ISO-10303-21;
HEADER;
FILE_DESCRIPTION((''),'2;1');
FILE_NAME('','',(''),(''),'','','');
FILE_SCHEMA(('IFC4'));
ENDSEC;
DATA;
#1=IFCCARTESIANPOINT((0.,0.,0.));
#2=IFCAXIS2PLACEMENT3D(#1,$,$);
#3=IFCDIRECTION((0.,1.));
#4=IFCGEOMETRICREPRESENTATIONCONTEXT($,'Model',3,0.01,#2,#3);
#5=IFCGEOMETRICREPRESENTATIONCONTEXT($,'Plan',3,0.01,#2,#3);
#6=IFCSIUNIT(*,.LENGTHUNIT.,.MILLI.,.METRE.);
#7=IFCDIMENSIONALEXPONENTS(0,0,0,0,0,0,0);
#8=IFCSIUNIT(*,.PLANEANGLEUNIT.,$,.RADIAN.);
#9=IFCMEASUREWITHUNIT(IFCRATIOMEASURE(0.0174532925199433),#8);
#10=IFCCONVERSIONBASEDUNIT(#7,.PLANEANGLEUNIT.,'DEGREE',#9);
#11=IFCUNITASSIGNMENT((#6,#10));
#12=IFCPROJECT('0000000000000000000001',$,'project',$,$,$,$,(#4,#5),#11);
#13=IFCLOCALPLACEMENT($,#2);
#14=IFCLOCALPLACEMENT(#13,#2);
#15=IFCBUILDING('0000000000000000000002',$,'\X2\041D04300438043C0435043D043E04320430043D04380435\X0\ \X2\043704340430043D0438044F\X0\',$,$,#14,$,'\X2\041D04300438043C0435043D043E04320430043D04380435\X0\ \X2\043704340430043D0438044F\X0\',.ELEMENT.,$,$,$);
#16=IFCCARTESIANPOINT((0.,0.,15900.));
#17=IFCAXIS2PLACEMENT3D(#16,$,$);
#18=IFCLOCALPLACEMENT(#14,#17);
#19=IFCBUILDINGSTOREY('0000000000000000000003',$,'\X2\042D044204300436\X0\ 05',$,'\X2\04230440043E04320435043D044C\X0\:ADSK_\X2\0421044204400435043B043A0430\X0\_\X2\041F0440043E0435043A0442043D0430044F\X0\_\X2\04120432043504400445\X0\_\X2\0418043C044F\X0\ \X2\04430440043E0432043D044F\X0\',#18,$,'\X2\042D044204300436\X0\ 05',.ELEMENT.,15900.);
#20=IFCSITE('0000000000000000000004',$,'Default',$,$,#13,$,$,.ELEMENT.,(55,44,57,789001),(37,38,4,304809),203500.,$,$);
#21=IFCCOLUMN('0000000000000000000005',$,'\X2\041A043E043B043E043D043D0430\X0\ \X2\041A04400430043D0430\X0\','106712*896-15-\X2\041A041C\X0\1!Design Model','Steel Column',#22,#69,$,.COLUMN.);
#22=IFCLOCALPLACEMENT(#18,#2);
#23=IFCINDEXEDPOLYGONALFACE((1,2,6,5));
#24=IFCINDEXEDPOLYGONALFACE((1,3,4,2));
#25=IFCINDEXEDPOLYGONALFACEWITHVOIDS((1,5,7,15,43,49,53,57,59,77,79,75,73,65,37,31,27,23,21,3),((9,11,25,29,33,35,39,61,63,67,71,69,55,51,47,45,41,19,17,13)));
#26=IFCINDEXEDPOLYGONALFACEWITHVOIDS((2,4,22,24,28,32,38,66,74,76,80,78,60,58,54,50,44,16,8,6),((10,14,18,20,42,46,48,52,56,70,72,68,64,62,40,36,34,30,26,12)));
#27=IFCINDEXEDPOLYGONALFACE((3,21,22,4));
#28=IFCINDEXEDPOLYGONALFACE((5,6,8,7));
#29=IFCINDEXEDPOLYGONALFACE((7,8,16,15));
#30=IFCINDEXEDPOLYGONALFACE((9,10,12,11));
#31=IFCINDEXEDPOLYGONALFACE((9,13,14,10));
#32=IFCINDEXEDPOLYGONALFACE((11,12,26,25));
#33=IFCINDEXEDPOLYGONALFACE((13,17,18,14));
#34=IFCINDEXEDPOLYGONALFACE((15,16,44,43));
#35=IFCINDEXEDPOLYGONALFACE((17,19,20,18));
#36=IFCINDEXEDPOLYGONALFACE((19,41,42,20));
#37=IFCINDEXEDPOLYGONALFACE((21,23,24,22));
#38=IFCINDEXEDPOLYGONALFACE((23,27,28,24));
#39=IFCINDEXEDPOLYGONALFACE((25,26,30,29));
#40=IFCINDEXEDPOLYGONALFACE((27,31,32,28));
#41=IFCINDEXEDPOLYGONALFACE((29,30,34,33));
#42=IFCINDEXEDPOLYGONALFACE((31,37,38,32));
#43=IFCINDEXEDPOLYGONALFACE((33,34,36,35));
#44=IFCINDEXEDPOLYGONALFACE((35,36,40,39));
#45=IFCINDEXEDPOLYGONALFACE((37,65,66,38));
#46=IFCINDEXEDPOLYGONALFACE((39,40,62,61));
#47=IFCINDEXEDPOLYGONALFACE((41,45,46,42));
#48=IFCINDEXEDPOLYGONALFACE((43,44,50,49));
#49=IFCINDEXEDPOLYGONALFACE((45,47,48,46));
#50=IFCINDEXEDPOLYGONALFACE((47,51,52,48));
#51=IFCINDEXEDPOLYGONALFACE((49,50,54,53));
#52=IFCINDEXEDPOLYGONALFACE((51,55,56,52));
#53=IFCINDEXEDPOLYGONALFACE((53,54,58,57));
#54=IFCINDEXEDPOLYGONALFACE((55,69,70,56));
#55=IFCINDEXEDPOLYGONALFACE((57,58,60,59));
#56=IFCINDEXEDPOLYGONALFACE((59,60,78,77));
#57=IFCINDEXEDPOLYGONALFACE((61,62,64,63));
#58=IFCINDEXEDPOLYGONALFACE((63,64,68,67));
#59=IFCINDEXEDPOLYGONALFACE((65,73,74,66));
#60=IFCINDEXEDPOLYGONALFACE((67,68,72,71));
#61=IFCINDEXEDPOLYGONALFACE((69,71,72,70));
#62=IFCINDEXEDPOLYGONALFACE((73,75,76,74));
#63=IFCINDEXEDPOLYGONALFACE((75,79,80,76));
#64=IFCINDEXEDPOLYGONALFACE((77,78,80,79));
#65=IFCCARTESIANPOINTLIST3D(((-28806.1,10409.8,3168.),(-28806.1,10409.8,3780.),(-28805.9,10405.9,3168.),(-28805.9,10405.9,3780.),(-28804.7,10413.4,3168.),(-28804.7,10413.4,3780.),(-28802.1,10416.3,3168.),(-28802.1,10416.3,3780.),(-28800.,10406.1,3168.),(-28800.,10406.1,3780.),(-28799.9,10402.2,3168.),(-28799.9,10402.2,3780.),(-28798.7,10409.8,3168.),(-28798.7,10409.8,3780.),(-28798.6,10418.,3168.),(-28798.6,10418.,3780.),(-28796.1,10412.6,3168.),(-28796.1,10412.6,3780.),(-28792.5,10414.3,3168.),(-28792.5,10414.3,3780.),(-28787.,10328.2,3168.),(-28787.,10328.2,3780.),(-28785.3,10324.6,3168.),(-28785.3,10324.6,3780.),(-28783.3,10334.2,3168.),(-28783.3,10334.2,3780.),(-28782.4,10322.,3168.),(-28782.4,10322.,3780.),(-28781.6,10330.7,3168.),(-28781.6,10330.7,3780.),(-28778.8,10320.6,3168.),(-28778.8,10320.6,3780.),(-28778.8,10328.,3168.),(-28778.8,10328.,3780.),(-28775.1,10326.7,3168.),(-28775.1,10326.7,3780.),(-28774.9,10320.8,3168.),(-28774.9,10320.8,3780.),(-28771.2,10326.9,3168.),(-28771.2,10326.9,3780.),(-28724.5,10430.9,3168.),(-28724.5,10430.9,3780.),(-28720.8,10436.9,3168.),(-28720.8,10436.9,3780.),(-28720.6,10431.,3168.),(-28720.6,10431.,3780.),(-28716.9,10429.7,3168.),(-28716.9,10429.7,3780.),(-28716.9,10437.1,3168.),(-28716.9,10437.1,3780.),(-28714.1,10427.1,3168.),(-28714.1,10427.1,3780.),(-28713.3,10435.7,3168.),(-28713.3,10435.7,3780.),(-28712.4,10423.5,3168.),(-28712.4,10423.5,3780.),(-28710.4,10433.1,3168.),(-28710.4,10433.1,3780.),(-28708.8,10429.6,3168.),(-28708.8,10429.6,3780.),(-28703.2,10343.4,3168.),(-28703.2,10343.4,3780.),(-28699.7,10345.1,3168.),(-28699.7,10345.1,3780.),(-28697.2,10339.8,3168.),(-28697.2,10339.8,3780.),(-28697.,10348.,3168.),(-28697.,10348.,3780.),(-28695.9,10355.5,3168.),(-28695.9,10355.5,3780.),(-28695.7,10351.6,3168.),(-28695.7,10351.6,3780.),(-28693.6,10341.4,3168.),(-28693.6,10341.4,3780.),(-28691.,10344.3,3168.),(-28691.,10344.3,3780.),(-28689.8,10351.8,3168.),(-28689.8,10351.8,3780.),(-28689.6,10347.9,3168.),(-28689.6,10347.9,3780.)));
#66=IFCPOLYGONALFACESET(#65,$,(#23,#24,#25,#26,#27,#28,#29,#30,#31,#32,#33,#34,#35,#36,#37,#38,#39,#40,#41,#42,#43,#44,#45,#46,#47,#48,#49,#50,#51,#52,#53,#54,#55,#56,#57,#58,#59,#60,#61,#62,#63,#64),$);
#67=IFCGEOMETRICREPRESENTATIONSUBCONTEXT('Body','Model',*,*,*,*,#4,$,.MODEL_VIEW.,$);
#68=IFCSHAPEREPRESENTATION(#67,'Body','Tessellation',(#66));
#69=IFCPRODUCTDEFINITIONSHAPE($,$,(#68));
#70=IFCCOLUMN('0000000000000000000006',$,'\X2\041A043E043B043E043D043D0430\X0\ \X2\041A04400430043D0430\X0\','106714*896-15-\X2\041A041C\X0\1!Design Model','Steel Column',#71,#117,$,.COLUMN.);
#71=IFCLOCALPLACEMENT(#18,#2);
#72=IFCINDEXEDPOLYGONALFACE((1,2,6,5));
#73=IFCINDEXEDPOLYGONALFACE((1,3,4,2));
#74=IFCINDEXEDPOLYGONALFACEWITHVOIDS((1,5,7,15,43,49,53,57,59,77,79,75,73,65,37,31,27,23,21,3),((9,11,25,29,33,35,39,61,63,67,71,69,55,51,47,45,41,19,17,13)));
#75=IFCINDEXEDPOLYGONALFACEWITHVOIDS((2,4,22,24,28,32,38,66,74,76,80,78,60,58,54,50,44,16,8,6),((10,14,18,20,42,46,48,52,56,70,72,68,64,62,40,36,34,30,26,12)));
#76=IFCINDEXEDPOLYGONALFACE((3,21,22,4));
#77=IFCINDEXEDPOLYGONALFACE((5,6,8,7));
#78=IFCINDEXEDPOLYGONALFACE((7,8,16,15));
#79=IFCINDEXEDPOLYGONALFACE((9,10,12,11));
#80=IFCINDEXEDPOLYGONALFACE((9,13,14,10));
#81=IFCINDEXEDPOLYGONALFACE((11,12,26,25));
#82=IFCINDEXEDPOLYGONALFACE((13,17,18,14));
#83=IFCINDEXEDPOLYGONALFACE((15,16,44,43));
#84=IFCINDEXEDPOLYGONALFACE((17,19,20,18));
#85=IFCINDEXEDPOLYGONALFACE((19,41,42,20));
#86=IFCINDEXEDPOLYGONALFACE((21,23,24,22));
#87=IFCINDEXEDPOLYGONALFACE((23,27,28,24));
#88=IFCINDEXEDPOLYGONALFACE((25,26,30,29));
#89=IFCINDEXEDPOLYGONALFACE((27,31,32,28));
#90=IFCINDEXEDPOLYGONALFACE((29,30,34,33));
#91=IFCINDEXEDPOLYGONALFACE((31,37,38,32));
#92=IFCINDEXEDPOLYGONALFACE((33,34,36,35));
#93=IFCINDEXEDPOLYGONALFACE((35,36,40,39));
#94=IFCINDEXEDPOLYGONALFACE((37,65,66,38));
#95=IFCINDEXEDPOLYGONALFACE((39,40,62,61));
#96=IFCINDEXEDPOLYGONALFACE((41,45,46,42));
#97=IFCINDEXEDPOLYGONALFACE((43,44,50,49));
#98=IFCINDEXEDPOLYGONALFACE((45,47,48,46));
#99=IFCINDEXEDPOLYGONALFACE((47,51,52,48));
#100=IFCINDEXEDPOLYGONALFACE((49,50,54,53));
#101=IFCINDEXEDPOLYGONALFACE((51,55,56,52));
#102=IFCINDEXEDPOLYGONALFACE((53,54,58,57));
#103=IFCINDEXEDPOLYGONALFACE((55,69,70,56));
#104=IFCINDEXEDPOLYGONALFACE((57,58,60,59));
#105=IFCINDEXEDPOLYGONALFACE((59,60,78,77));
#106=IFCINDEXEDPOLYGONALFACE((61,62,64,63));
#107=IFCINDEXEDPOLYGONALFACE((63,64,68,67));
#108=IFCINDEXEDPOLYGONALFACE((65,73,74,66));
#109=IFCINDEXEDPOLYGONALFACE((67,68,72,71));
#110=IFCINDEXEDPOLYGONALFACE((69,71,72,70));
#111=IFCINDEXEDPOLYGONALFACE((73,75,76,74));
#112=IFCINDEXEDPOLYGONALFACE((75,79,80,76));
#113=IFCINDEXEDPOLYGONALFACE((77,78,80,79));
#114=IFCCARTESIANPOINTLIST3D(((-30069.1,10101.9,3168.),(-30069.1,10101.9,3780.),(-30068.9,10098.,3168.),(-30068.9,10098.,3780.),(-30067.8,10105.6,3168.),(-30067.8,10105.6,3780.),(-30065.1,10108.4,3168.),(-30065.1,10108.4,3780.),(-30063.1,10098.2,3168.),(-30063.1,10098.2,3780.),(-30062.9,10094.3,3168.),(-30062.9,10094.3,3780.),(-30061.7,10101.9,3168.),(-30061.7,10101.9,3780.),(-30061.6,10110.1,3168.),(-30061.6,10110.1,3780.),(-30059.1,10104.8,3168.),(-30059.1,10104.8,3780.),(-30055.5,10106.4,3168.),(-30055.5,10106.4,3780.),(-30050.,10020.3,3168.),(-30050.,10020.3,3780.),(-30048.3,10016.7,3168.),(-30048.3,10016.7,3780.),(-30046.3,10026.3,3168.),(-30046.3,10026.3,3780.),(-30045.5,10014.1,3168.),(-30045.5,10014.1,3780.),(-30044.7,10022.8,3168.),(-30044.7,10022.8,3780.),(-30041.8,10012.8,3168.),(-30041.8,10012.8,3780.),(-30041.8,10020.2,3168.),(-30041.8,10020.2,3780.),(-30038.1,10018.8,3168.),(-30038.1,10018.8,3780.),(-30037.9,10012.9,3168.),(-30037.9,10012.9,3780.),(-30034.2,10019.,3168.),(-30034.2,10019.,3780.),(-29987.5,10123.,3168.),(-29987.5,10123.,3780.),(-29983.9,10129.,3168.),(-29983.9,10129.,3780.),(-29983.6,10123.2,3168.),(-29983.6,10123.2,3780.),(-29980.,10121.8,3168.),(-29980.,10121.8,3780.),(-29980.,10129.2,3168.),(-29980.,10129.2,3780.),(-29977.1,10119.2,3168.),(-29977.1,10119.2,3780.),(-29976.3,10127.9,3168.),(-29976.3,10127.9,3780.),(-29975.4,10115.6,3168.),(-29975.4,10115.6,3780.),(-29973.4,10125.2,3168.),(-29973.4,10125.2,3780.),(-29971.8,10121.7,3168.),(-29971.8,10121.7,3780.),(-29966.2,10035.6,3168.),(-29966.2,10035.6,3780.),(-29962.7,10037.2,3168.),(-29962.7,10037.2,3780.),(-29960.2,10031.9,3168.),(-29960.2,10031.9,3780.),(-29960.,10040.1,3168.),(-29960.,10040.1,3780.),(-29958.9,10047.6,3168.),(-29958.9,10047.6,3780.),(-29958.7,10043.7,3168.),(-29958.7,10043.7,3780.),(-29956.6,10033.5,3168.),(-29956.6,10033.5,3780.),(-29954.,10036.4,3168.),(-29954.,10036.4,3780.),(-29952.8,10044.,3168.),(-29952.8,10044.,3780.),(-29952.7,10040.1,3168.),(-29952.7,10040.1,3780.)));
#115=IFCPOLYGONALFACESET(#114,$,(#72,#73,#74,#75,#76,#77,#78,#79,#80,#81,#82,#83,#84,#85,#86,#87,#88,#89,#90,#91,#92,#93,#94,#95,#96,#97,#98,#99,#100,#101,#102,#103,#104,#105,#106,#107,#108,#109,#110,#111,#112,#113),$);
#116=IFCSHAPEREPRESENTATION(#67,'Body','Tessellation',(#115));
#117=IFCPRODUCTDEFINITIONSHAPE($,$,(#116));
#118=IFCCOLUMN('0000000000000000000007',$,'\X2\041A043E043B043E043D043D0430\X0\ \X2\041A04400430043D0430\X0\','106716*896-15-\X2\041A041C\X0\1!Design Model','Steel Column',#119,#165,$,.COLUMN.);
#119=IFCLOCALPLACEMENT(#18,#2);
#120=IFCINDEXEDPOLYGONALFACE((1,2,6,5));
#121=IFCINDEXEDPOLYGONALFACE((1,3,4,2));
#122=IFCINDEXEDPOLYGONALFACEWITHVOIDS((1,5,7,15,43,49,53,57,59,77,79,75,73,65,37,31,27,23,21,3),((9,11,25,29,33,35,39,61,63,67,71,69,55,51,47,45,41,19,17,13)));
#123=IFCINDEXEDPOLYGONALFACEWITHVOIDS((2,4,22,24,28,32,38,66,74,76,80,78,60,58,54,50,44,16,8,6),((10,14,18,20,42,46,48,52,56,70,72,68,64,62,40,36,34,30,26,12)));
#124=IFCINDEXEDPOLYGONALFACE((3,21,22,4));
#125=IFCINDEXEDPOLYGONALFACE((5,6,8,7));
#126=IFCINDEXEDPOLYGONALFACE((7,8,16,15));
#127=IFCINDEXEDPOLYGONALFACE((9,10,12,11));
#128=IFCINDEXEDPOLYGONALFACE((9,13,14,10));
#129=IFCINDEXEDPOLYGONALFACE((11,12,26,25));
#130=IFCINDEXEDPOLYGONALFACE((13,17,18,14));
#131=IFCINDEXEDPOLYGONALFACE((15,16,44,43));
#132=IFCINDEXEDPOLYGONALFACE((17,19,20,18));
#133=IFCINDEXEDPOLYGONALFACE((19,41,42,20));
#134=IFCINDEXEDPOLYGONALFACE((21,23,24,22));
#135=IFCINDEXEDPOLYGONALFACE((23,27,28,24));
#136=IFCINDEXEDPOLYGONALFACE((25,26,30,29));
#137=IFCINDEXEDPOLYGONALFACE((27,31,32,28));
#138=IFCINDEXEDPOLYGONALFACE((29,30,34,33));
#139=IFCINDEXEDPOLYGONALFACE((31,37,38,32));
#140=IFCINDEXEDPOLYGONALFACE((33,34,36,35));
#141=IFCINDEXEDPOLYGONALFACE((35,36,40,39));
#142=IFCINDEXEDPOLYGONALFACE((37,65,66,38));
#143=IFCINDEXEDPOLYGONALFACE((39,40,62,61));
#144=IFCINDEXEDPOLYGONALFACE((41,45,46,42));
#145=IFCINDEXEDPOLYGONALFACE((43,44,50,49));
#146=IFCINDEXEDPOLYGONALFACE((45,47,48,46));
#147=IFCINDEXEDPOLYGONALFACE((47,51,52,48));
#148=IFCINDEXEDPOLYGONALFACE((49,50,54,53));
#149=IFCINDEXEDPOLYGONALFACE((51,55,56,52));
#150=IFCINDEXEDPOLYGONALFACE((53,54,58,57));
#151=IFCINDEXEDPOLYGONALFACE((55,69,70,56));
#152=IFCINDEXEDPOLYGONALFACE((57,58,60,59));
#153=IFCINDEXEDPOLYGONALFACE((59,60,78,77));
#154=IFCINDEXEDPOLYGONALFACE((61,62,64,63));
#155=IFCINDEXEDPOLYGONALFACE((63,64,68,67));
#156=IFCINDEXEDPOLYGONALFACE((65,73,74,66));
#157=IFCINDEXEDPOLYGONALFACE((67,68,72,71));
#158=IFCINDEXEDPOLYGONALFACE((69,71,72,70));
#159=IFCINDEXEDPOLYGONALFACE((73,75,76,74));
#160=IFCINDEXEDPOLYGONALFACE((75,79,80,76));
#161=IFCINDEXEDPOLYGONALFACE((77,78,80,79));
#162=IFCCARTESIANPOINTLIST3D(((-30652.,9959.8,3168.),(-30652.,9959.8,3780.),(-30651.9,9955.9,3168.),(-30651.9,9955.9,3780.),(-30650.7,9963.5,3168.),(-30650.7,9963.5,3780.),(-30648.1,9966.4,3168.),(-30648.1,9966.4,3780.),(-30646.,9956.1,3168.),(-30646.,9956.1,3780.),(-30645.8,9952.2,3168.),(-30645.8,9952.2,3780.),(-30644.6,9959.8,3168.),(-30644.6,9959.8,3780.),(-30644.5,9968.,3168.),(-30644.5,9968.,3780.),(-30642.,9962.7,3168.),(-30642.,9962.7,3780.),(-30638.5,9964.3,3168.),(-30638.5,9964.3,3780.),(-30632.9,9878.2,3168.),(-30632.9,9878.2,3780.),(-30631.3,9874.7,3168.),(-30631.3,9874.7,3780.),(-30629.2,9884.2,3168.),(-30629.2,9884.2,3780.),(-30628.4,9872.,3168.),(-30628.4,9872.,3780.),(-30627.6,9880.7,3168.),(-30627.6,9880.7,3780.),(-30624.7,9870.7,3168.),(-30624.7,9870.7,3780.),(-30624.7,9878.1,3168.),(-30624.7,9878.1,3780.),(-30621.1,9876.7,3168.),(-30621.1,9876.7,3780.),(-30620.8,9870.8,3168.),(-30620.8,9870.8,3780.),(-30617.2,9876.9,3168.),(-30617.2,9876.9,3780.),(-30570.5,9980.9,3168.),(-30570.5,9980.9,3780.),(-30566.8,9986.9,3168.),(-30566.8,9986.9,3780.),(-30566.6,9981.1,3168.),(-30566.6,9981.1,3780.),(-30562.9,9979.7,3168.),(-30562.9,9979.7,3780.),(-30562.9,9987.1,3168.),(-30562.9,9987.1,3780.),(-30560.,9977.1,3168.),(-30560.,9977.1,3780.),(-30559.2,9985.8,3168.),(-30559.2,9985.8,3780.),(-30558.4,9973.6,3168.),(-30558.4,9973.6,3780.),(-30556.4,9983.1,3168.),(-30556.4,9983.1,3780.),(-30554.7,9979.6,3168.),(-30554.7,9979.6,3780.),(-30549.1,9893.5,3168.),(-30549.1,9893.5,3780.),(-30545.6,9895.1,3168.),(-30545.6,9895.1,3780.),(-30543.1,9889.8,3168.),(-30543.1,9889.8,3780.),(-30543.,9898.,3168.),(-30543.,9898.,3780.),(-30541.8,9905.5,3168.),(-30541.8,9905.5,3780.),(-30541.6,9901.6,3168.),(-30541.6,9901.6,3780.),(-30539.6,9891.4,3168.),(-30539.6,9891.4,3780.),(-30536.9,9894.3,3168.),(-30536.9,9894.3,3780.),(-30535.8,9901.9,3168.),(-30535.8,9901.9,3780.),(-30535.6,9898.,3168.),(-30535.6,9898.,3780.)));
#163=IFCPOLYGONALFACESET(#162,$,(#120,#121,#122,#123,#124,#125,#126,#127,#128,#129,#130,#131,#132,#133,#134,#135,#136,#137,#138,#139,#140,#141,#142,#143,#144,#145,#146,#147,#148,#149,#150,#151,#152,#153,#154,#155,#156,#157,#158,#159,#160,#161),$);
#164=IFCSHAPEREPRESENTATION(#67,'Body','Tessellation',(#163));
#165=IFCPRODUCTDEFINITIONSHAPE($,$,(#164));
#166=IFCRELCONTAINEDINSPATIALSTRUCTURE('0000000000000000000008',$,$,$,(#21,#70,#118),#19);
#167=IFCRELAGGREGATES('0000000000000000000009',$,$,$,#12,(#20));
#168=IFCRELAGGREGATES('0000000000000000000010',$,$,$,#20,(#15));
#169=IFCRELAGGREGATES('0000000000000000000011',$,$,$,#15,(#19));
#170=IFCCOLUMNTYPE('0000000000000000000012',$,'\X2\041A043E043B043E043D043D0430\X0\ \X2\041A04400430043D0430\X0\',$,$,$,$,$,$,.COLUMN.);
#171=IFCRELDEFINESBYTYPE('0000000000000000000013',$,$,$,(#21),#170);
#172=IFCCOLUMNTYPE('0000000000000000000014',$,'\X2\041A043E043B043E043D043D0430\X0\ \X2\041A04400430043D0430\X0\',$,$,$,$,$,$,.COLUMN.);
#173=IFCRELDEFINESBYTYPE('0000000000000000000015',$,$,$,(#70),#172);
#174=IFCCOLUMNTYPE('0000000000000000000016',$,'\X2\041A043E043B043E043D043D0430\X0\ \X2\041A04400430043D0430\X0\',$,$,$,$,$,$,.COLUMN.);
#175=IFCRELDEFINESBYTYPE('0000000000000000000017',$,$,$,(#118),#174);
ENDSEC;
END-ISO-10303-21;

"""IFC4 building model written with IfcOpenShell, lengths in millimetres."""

from ifc_helpers import new_model, entity, si_unit, converted_unit, direction, frame, origin, place, context, subcontext, project, spatial, indexed_curve, outline, extrude, type_object, element, save


model = new_model("IFC4")

# Units and contexts
model_context = context("Model", 3, precision=0.01, world=origin(), true_north=direction((0.0, 1.0)))
plan_context = context("Plan", 3, precision=0.01, world=origin(), true_north=direction((0.0, 1.0)))
body_context = subcontext(model_context, "Body", "Model", "MODEL_VIEW")
ifc_project = project(units=[si_unit("LENGTHUNIT", "METRE", prefix="MILLI"), converted_unit("PLANEANGLEUNIT", "DEGREE", entity("IfcRatioMeasure", 0.0174532925199433), si_unit("PLANEANGLEUNIT", "RADIAN"), dimensions=[0, 0, 0, 0, 0, 0, 0])], contexts=[model_context, plan_context])

# Site, building, storey
site_placement = place(None, origin())
site = spatial("IfcSite", under=ifc_project, at=site_placement, Name="Default", CompositionType="ELEMENT", RefLatitude=(55, 44, 57, 789001), RefLongitude=(37, 38, 4, 304809), RefElevation=203500.0)
building_placement = place(site_placement, origin())
building = spatial("IfcBuilding", under=site, at=building_placement, Name="Наименование здания", LongName="Наименование здания", CompositionType="ELEMENT")
storey_placement = place(building_placement, frame((0.0, 0.0, 15900.0)))
storey = spatial("IfcBuildingStorey", under=building, at=storey_placement, Name="Этаж 05", ObjectType="Уровень:ADSK_Стрелка_Проектная_Вверх_Имя уровня", LongName="Этаж 05", CompositionType="ELEMENT", Elevation=15900.0)

# Columns
column_type_1 = type_object("IfcColumnType", Name="Колонна Крана", PredefinedType="COLUMN")
column_1_placement = place(storey_placement, origin())
element("IfcColumn", 1, at=column_1_placement, inside=storey, type_object=column_type_1, Name="Колонна Крана", Description="106712*896-15-КМ1!Design Model", ObjectType="Steel Column", PredefinedType="COLUMN", context=body_context, shape_type="SweptSolid", body=[
    extrude(outline(indexed_curve([(29.5, -56.8), (33.4, -56.8), (37.0, -55.3), (39.7, -52.6), (41.2, -49.0), (56.8, 29.5), (56.8, 33.4), (55.3, 37.0), (52.6, 39.7), (49.0, 41.2), (-29.5, 56.8), (-33.4, 56.8), (-37.0, 55.3), (-39.7, 52.6), (-41.2, 49.0), (-56.8, -29.5), (-56.8, -33.4), (-55.3, -37.0), (-52.6, -39.7), (-49.0, -41.2), (29.5, -56.8)], self_intersect=False), holes=[indexed_curve([(-43.1, -37.3), (-46.7, -35.8), (-49.5, -33.1), (-51.0, -29.5), (-51.0, -25.5), (-37.3, 43.1), (-35.8, 46.7), (-33.1, 49.5), (-29.5, 51.0), (-25.5, 51.0), (43.1, 37.3), (46.7, 35.8), (49.5, 33.1), (51.0, 29.5), (51.0, 25.5), (37.3, -43.1), (35.8, -46.7), (33.1, -49.5), (29.5, -51.0), (25.5, -51.0), (-43.1, -37.3)], self_intersect=False)]), frame((-28747.9, 10378.9, 3168.0), z_axis=(0.0, 0.0, 1.0), x_axis=(-0.906681, -0.421816, 0.0)), (0.0, 0.0, 1.0), 612.0),
])
column_type_2 = type_object("IfcColumnType", Name="Колонна Крана", PredefinedType="COLUMN")
column_2_placement = place(storey_placement, origin())
element("IfcColumn", 2, at=column_2_placement, inside=storey, type_object=column_type_2, Name="Колонна Крана", Description="106714*896-15-КМ1!Design Model", ObjectType="Steel Column", PredefinedType="COLUMN", context=body_context, shape_type="SweptSolid", body=[
    extrude(outline(indexed_curve([(29.5, -56.8), (33.4, -56.8), (37.0, -55.3), (39.7, -52.6), (41.2, -49.0), (56.8, 29.5), (56.8, 33.4), (55.3, 37.0), (52.6, 39.7), (49.0, 41.2), (-29.5, 56.8), (-33.4, 56.8), (-37.0, 55.3), (-39.7, 52.6), (-41.2, 49.0), (-56.8, -29.5), (-56.8, -33.4), (-55.3, -37.0), (-52.6, -39.7), (-49.0, -41.2), (29.5, -56.8)], self_intersect=False), holes=[indexed_curve([(-43.1, -37.3), (-46.7, -35.8), (-49.5, -33.1), (-51.0, -29.5), (-51.0, -25.5), (-37.3, 43.1), (-35.8, 46.7), (-33.1, 49.5), (-29.5, 51.0), (-25.5, 51.0), (43.1, 37.3), (46.7, 35.8), (49.5, 33.1), (51.0, 29.5), (51.0, 25.5), (37.3, -43.1), (35.8, -46.7), (33.1, -49.5), (29.5, -51.0), (25.5, -51.0), (-43.1, -37.3)], self_intersect=False)]), frame((-30010.9, 10071.0, 3168.0), z_axis=(0.0, 0.0, 1.0), x_axis=(-0.906681, -0.421816, 0.0)), (0.0, 0.0, 1.0), 612.0),
])
column_type_3 = type_object("IfcColumnType", Name="Колонна Крана", PredefinedType="COLUMN")
column_3_placement = place(storey_placement, origin())
element("IfcColumn", 3, at=column_3_placement, inside=storey, type_object=column_type_3, Name="Колонна Крана", Description="106716*896-15-КМ1!Design Model", ObjectType="Steel Column", PredefinedType="COLUMN", context=body_context, shape_type="SweptSolid", body=[
    extrude(outline(indexed_curve([(29.5, -56.8), (33.4, -56.8), (37.0, -55.3), (39.7, -52.6), (41.2, -49.0), (56.8, 29.5), (56.8, 33.4), (55.3, 37.0), (52.6, 39.7), (49.0, 41.2), (-29.5, 56.8), (-33.4, 56.8), (-37.0, 55.3), (-39.7, 52.6), (-41.2, 49.0), (-56.8, -29.5), (-56.8, -33.4), (-55.3, -37.0), (-52.6, -39.7), (-49.0, -41.2), (29.5, -56.8)], self_intersect=False), holes=[indexed_curve([(-43.1, -37.3), (-46.7, -35.8), (-49.5, -33.1), (-51.0, -29.5), (-51.0, -25.5), (-37.3, 43.1), (-35.8, 46.7), (-33.1, 49.5), (-29.5, 51.0), (-25.5, 51.0), (43.1, 37.3), (46.7, 35.8), (49.5, 33.1), (51.0, 29.5), (51.0, 25.5), (37.3, -43.1), (35.8, -46.7), (33.1, -49.5), (29.5, -51.0), (25.5, -51.0), (-43.1, -37.3)], self_intersect=False)]), frame((-30593.8, 9928.9, 3168.0), z_axis=(0.0, 0.0, 1.0), x_axis=(-0.906681, -0.421816, 0.0)), (0.0, 0.0, 1.0), 612.0),
])

save(model, "model.ifc")
